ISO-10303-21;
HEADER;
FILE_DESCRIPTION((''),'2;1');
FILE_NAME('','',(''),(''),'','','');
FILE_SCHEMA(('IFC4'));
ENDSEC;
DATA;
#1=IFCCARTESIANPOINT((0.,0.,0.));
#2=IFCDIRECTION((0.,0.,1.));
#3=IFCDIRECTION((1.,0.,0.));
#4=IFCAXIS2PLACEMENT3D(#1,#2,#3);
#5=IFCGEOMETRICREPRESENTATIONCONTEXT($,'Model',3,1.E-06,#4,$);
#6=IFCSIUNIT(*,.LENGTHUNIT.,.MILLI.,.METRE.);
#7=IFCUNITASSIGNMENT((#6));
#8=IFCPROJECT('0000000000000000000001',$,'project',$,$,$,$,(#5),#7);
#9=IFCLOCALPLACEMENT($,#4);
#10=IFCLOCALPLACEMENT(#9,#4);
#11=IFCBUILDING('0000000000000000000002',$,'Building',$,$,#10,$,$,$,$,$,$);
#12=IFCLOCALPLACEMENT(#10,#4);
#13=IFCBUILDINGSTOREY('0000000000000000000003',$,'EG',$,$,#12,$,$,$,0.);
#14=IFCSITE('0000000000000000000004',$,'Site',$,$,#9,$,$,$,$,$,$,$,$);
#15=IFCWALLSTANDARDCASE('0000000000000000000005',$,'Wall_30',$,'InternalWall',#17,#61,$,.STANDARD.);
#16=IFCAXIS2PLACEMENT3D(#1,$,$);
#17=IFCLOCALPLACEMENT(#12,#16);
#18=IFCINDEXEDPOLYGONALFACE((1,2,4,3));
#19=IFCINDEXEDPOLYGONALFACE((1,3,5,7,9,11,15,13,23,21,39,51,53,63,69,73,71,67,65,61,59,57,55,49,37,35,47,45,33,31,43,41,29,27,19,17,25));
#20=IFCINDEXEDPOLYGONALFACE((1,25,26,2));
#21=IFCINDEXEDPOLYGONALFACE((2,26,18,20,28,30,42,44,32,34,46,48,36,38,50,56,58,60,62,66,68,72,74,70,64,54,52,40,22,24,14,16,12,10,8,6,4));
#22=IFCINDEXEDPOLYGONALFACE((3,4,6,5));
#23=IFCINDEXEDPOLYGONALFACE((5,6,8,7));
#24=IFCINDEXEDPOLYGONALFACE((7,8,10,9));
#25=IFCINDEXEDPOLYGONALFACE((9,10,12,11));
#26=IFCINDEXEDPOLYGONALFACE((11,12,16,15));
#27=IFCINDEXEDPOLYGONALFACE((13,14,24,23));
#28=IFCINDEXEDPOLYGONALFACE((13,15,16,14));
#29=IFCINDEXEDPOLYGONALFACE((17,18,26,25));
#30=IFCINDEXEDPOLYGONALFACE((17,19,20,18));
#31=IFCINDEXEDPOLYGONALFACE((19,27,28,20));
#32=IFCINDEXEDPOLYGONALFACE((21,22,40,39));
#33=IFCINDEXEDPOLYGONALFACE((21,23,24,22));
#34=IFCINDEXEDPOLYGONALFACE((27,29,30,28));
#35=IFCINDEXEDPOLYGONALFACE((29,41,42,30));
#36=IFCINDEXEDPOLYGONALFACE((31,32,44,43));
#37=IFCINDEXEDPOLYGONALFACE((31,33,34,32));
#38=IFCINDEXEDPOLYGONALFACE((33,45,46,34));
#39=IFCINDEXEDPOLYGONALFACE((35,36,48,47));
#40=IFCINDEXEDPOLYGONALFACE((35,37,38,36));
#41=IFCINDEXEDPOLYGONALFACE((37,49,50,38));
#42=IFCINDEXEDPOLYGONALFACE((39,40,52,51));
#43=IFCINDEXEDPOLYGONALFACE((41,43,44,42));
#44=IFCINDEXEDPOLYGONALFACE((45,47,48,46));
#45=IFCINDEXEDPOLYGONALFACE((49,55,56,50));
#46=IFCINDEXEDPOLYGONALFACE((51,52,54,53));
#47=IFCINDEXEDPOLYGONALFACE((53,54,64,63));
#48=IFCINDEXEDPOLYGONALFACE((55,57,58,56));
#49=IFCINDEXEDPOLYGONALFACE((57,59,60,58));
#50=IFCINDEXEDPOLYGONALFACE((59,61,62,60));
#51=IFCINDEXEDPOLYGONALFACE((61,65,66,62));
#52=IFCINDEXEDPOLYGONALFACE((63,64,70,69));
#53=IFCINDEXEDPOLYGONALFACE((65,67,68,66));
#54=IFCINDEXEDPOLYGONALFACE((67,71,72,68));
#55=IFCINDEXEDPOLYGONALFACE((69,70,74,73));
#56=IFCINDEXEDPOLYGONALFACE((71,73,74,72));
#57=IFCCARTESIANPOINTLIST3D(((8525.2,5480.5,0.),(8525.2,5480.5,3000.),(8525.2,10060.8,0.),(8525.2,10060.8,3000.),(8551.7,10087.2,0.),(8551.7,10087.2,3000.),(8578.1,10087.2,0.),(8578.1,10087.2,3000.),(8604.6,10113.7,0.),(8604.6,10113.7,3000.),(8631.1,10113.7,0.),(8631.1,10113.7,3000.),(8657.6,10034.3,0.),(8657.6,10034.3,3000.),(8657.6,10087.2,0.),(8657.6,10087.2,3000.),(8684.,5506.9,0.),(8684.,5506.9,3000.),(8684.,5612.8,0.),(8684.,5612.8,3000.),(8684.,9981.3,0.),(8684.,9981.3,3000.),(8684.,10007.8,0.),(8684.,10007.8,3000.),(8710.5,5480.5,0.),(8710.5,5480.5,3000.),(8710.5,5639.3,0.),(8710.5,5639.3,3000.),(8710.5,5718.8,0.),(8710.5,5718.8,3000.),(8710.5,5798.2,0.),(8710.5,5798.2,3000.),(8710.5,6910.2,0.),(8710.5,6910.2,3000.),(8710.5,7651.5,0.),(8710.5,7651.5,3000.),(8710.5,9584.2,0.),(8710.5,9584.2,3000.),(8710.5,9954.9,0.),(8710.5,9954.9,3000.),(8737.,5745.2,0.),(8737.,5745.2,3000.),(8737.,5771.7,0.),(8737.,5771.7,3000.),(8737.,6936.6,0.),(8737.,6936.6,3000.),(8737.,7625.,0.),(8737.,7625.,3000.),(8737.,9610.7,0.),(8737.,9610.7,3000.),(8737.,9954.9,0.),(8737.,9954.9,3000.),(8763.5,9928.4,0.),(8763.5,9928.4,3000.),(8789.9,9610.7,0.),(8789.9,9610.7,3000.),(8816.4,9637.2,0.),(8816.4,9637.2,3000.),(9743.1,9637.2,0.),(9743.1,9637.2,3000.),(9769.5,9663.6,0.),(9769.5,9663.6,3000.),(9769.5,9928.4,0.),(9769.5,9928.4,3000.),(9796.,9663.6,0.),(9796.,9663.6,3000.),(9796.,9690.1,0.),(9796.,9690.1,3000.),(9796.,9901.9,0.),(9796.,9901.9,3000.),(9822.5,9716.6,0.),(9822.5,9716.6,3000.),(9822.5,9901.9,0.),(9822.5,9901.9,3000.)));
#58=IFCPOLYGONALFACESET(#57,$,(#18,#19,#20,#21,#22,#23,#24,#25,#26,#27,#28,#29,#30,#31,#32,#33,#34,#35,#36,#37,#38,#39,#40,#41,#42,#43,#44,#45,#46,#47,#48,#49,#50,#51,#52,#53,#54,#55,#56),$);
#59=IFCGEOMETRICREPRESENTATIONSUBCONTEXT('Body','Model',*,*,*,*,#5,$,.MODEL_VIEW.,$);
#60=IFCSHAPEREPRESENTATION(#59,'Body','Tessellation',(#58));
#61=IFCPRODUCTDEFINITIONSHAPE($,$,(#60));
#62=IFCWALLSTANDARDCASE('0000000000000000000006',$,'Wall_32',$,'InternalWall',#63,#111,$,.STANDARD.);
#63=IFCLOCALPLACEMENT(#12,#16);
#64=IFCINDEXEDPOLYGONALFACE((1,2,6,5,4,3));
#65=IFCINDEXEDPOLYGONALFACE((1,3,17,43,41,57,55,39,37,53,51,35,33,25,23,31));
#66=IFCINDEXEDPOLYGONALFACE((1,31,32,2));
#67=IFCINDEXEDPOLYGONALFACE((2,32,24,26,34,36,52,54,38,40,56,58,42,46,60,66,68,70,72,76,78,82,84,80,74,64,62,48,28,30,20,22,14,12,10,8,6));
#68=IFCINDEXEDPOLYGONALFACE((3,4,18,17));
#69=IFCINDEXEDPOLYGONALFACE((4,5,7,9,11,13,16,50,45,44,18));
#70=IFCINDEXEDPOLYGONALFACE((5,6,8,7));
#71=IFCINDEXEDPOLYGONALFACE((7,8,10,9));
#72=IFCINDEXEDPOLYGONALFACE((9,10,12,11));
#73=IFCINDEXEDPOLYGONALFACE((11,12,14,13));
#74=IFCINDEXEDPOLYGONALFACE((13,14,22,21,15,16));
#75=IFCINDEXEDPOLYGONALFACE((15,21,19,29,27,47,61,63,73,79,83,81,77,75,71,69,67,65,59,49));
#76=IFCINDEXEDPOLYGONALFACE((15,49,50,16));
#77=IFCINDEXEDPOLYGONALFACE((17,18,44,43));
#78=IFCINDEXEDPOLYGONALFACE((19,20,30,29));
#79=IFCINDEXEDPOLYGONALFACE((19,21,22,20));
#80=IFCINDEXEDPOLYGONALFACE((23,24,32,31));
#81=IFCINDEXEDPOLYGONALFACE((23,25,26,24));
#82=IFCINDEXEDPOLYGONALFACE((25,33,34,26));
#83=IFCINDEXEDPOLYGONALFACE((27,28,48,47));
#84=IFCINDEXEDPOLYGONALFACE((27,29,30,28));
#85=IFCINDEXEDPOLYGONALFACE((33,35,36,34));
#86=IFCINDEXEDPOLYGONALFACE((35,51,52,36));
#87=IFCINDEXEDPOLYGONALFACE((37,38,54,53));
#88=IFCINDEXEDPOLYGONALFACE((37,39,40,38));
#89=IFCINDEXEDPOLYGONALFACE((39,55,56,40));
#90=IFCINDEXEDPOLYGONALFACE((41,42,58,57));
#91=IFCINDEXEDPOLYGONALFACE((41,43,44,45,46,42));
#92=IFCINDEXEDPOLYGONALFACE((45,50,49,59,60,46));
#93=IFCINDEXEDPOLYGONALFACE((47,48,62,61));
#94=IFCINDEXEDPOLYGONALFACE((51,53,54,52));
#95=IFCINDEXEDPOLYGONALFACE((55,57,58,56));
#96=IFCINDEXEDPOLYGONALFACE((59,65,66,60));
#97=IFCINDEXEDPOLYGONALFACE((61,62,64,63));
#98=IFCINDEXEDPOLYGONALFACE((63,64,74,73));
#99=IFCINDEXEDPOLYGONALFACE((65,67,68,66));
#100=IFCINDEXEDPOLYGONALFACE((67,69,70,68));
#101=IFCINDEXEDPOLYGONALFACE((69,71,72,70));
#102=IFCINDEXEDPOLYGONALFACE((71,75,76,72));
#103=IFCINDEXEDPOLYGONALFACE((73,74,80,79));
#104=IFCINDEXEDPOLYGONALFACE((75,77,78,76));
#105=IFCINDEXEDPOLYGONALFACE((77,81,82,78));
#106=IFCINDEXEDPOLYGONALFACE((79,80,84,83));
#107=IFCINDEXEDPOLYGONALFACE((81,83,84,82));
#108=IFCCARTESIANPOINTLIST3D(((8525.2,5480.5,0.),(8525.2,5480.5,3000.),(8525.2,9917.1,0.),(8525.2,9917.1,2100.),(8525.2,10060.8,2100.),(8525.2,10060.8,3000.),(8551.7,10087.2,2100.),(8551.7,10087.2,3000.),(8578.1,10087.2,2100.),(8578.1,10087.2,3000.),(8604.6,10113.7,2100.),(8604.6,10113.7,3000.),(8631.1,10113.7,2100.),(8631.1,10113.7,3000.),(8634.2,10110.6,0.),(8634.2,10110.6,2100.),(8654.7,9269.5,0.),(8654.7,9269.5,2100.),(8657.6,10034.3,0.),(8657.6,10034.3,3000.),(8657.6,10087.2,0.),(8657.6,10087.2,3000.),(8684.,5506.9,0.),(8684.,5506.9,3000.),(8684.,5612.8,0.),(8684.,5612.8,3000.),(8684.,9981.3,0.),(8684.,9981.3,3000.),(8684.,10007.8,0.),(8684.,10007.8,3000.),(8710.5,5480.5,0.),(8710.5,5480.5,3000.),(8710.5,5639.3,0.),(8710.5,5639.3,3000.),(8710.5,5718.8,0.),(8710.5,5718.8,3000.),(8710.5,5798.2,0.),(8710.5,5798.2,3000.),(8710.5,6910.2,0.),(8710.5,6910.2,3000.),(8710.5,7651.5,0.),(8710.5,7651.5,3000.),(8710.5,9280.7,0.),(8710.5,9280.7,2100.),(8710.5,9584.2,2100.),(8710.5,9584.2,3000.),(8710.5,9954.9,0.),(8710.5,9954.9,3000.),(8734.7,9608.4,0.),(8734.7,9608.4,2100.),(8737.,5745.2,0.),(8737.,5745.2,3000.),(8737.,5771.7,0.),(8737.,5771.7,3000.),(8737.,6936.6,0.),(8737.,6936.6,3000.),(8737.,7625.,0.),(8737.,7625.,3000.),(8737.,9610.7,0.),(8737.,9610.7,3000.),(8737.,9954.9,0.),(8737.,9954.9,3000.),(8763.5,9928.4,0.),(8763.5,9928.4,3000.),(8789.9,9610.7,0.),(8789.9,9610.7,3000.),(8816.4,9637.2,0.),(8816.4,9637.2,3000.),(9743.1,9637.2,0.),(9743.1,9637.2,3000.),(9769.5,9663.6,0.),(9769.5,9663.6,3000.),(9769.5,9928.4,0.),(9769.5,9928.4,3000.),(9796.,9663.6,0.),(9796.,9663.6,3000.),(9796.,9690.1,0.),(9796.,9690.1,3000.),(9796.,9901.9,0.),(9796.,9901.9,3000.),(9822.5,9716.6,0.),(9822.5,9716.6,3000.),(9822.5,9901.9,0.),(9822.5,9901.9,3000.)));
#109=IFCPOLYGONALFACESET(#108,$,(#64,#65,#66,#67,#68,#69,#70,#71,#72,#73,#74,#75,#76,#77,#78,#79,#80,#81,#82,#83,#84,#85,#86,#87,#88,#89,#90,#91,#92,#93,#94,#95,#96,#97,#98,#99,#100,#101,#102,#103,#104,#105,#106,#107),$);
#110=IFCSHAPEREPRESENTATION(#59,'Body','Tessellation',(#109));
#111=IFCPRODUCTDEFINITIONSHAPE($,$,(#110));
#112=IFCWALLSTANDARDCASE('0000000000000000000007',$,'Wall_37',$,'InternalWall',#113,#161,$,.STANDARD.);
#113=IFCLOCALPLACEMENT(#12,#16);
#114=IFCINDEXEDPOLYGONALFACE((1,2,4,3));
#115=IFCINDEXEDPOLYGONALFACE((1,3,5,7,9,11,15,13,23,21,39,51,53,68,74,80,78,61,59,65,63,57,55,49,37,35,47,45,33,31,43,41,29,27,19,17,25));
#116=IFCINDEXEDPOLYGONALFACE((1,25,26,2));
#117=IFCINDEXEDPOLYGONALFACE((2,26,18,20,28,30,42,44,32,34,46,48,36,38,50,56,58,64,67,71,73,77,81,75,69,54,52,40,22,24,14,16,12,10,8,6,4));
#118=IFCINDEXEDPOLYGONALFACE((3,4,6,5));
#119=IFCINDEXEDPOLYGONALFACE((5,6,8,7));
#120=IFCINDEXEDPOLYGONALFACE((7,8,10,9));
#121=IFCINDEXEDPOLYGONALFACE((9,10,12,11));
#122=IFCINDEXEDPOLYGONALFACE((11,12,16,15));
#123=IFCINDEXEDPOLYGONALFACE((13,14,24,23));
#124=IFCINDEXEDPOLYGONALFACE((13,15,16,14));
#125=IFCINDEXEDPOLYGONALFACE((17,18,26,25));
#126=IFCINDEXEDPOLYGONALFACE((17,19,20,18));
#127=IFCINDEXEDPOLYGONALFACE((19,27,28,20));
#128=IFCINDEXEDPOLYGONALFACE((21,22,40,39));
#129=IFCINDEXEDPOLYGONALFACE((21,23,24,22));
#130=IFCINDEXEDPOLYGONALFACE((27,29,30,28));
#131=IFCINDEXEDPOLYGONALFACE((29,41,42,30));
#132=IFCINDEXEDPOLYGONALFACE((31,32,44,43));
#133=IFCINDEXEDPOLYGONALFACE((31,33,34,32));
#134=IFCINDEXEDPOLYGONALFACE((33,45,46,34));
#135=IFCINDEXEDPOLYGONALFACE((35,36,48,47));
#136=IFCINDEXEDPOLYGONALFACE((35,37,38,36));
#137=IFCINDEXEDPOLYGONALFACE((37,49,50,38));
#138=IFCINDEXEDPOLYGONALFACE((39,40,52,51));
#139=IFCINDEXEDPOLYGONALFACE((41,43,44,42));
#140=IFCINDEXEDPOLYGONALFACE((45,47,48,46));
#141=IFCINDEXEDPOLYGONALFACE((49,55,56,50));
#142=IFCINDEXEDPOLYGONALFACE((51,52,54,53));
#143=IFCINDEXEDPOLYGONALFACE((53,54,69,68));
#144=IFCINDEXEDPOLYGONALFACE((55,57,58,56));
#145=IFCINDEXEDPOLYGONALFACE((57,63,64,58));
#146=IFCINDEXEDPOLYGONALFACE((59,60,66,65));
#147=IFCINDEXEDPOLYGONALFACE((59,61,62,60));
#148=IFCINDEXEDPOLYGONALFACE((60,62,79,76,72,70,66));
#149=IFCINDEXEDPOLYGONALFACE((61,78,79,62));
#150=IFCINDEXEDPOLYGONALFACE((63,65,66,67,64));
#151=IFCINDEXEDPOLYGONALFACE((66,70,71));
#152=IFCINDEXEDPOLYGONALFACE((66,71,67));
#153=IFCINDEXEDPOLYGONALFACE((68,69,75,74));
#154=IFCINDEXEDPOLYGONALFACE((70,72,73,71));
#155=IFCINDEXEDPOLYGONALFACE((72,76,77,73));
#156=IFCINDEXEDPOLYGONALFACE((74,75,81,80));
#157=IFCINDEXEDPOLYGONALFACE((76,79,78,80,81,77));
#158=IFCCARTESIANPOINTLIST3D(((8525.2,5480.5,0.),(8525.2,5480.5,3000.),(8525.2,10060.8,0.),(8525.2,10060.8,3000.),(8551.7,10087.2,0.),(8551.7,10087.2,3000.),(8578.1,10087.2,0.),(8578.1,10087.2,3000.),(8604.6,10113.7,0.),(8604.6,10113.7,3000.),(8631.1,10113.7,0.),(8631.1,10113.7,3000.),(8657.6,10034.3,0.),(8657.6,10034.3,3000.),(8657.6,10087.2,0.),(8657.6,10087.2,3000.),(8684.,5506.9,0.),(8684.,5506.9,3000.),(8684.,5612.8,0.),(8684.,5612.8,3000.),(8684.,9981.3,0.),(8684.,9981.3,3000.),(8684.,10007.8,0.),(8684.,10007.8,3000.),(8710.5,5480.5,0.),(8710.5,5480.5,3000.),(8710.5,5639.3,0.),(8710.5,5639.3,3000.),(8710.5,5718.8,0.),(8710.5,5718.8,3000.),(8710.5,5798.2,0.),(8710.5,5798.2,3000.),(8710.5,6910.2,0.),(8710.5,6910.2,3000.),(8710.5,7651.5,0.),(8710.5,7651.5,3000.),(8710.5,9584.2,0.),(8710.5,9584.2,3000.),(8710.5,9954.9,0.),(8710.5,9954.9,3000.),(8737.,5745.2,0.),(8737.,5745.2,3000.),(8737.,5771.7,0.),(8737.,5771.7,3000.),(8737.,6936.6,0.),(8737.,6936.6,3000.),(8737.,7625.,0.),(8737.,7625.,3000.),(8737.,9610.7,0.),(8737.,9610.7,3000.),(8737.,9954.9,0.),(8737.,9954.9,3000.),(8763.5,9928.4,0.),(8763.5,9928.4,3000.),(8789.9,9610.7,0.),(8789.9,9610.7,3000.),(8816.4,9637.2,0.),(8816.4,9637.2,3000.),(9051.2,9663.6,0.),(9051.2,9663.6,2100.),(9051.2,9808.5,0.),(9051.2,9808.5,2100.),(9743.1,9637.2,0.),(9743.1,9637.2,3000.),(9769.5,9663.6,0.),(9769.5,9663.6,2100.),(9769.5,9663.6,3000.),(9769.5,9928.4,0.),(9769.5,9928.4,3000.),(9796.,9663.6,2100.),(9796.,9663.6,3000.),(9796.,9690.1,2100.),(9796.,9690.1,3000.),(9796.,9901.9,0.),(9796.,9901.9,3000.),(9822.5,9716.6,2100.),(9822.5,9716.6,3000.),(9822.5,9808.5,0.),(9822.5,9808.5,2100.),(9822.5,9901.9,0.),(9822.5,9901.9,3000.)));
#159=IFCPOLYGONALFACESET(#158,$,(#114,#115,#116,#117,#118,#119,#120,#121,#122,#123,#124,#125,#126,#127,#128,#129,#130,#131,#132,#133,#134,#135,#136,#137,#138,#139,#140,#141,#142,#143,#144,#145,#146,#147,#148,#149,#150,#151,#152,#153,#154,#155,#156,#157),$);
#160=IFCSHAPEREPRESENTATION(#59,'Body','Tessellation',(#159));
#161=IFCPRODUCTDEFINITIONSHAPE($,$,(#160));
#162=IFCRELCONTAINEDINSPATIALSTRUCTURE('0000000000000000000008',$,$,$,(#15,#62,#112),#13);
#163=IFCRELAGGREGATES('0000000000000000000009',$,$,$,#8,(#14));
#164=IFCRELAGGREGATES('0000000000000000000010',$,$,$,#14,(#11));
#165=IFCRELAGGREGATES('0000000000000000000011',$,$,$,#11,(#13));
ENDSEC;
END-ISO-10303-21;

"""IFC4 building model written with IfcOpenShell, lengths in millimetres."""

from ifc_helpers import new_model, si_unit, frame, origin_with_axes, place, context, subcontext, project, spatial, polyline, rectangle, outline, extrude, element, save


model = new_model("IFC4")

# Units and contexts
model_context = context("Model", 3, precision=1e-06, world=origin_with_axes())
body_context = subcontext(model_context, "Body", "Model", "MODEL_VIEW")
ifc_project = project(units=[si_unit("LENGTHUNIT", "METRE", prefix="MILLI")], contexts=[model_context])

# Site, building, storey
site_placement = place(None, origin_with_axes())
site = spatial("IfcSite", under=ifc_project, at=site_placement, Name="Site")
building_placement = place(site_placement, origin_with_axes())
building = spatial("IfcBuilding", under=site, at=building_placement, Name="Building")
storey_placement = place(building_placement, origin_with_axes())
storey = spatial("IfcBuildingStorey", under=building, at=storey_placement, Name="EG", Elevation=0.0)

# Wall
for number, where, z_axis, x_axis, name in (
    (1, (0.0, 0.0, 0.0), (0.0, 0.0, 1.0), (1.0, 0.0, 0.0), "Wall_30"),
):
    element("IfcWallStandardCase", number, at=place(storey_placement, frame(where, z_axis=z_axis, x_axis=x_axis)), inside=storey, Name=name, ObjectType="InternalWall", PredefinedType="STANDARD", context=body_context, shape_type="SweptSolid", body=[
        extrude(outline(polyline([(8525.2, 5480.5, 0.0), (8525.2, 10060.8, 0.0), (8551.7, 10087.2, 0.0), (8578.1, 10087.2, 0.0), (8604.6, 10113.7, 0.0), (8631.1, 10113.7, 0.0), (8657.6, 10087.2, 0.0), (8657.6, 10034.3, 0.0), (8684.0, 10007.8, 0.0), (8684.0, 9981.3, 0.0), (8710.5, 9954.9, 0.0), (8737.0, 9954.9, 0.0), (8763.5, 9928.4, 0.0), (9769.5, 9928.4, 0.0), (9796.0, 9901.9, 0.0), (9822.5, 9901.9, 0.0), (9822.5, 9716.6, 0.0), (9796.0, 9690.1, 0.0), (9796.0, 9663.6, 0.0), (9769.5, 9663.6, 0.0), (9743.1, 9637.2, 0.0), (8816.4, 9637.2, 0.0), (8789.9, 9610.7, 0.0), (8737.0, 9610.7, 0.0), (8710.5, 9584.2, 0.0), (8710.5, 7651.5, 0.0), (8737.0, 7625.0, 0.0), (8737.0, 6936.6, 0.0), (8710.5, 6910.2, 0.0), (8710.5, 5798.2, 0.0), (8737.0, 5771.7, 0.0), (8737.0, 5745.2, 0.0), (8710.5, 5718.8, 0.0), (8710.5, 5639.3, 0.0), (8684.0, 5612.8, 0.0), (8684.0, 5506.9, 0.0), (8710.5, 5480.5, 0.0), (8525.2, 5480.5, 0.0)])), origin_with_axes(), (0.0, 0.0, 1.0), 3000.0),
    ])

# Wall, opening
wall_1_placement = place(storey_placement, origin_with_axes())
wall_1 = element("IfcWallStandardCase", 2, at=wall_1_placement, inside=storey, Name="Wall_32", ObjectType="InternalWall", PredefinedType="STANDARD", context=body_context, shape_type="SweptSolid", body=[
    extrude(outline(polyline([(8525.2, 5480.5, 0.0), (8525.2, 10060.8, 0.0), (8551.7, 10087.2, 0.0), (8578.1, 10087.2, 0.0), (8604.6, 10113.7, 0.0), (8631.1, 10113.7, 0.0), (8657.6, 10087.2, 0.0), (8657.6, 10034.3, 0.0), (8684.0, 10007.8, 0.0), (8684.0, 9981.3, 0.0), (8710.5, 9954.9, 0.0), (8737.0, 9954.9, 0.0), (8763.5, 9928.4, 0.0), (9769.5, 9928.4, 0.0), (9796.0, 9901.9, 0.0), (9822.5, 9901.9, 0.0), (9822.5, 9716.6, 0.0), (9796.0, 9690.1, 0.0), (9796.0, 9663.6, 0.0), (9769.5, 9663.6, 0.0), (9743.1, 9637.2, 0.0), (8816.4, 9637.2, 0.0), (8789.9, 9610.7, 0.0), (8737.0, 9610.7, 0.0), (8710.5, 9584.2, 0.0), (8710.5, 7651.5, 0.0), (8737.0, 7625.0, 0.0), (8737.0, 6936.6, 0.0), (8710.5, 6910.2, 0.0), (8710.5, 5798.2, 0.0), (8737.0, 5771.7, 0.0), (8737.0, 5745.2, 0.0), (8710.5, 5718.8, 0.0), (8710.5, 5639.3, 0.0), (8684.0, 5612.8, 0.0), (8684.0, 5506.9, 0.0), (8710.5, 5480.5, 0.0), (8525.2, 5480.5, 0.0)])), origin_with_axes(), (0.0, 0.0, 1.0), 3000.0),
])
opening_1_placement = place(wall_1_placement, origin_with_axes())
element("IfcOpeningElement", 3, at=opening_1_placement, inside=storey, cuts=wall_1, context=body_context, shape_type="SweptSolid", body=[
    extrude(rectangle(XDim=1344.8, YDim=144.9), frame((8593.8, 9943.1, 0.0), z_axis=(0.0, 0.0, 1.0), x_axis=(-0.196116, 0.980581, 0.0)), (0.0, 0.0, 1.0), 2100.0),
])

# Wall, opening
wall_2_placement = place(storey_placement, origin_with_axes())
wall_2 = element("IfcWallStandardCase", 4, at=wall_2_placement, inside=storey, Name="Wall_37", ObjectType="InternalWall", PredefinedType="STANDARD", context=body_context, shape_type="SweptSolid", body=[
    extrude(outline(polyline([(8525.2, 5480.5, 0.0), (8525.2, 10060.8, 0.0), (8551.7, 10087.2, 0.0), (8578.1, 10087.2, 0.0), (8604.6, 10113.7, 0.0), (8631.1, 10113.7, 0.0), (8657.6, 10087.2, 0.0), (8657.6, 10034.3, 0.0), (8684.0, 10007.8, 0.0), (8684.0, 9981.3, 0.0), (8710.5, 9954.9, 0.0), (8737.0, 9954.9, 0.0), (8763.5, 9928.4, 0.0), (9769.5, 9928.4, 0.0), (9796.0, 9901.9, 0.0), (9822.5, 9901.9, 0.0), (9822.5, 9716.6, 0.0), (9796.0, 9690.1, 0.0), (9796.0, 9663.6, 0.0), (9769.5, 9663.6, 0.0), (9743.1, 9637.2, 0.0), (8816.4, 9637.2, 0.0), (8789.9, 9610.7, 0.0), (8737.0, 9610.7, 0.0), (8710.5, 9584.2, 0.0), (8710.5, 7651.5, 0.0), (8737.0, 7625.0, 0.0), (8737.0, 6936.6, 0.0), (8710.5, 6910.2, 0.0), (8710.5, 5798.2, 0.0), (8737.0, 5771.7, 0.0), (8737.0, 5745.2, 0.0), (8710.5, 5718.8, 0.0), (8710.5, 5639.3, 0.0), (8684.0, 5612.8, 0.0), (8684.0, 5506.9, 0.0), (8710.5, 5480.5, 0.0), (8525.2, 5480.5, 0.0)])), origin_with_axes(), (0.0, 0.0, 1.0), 3000.0),
])
opening_2_placement = place(wall_2_placement, origin_with_axes())
element("IfcOpeningElement", 5, at=opening_2_placement, inside=storey, cuts=wall_2, context=body_context, shape_type="SweptSolid", body=[
    extrude(rectangle(XDim=1347.9, YDim=144.9), frame((9725.2, 9736.0, 0.0), z_axis=(0.0, 0.0, 1.0), x_axis=(1.0, 0.0, 0.0)), (0.0, 0.0, 1.0), 2100.0),
])

save(model, "model.ifc")
